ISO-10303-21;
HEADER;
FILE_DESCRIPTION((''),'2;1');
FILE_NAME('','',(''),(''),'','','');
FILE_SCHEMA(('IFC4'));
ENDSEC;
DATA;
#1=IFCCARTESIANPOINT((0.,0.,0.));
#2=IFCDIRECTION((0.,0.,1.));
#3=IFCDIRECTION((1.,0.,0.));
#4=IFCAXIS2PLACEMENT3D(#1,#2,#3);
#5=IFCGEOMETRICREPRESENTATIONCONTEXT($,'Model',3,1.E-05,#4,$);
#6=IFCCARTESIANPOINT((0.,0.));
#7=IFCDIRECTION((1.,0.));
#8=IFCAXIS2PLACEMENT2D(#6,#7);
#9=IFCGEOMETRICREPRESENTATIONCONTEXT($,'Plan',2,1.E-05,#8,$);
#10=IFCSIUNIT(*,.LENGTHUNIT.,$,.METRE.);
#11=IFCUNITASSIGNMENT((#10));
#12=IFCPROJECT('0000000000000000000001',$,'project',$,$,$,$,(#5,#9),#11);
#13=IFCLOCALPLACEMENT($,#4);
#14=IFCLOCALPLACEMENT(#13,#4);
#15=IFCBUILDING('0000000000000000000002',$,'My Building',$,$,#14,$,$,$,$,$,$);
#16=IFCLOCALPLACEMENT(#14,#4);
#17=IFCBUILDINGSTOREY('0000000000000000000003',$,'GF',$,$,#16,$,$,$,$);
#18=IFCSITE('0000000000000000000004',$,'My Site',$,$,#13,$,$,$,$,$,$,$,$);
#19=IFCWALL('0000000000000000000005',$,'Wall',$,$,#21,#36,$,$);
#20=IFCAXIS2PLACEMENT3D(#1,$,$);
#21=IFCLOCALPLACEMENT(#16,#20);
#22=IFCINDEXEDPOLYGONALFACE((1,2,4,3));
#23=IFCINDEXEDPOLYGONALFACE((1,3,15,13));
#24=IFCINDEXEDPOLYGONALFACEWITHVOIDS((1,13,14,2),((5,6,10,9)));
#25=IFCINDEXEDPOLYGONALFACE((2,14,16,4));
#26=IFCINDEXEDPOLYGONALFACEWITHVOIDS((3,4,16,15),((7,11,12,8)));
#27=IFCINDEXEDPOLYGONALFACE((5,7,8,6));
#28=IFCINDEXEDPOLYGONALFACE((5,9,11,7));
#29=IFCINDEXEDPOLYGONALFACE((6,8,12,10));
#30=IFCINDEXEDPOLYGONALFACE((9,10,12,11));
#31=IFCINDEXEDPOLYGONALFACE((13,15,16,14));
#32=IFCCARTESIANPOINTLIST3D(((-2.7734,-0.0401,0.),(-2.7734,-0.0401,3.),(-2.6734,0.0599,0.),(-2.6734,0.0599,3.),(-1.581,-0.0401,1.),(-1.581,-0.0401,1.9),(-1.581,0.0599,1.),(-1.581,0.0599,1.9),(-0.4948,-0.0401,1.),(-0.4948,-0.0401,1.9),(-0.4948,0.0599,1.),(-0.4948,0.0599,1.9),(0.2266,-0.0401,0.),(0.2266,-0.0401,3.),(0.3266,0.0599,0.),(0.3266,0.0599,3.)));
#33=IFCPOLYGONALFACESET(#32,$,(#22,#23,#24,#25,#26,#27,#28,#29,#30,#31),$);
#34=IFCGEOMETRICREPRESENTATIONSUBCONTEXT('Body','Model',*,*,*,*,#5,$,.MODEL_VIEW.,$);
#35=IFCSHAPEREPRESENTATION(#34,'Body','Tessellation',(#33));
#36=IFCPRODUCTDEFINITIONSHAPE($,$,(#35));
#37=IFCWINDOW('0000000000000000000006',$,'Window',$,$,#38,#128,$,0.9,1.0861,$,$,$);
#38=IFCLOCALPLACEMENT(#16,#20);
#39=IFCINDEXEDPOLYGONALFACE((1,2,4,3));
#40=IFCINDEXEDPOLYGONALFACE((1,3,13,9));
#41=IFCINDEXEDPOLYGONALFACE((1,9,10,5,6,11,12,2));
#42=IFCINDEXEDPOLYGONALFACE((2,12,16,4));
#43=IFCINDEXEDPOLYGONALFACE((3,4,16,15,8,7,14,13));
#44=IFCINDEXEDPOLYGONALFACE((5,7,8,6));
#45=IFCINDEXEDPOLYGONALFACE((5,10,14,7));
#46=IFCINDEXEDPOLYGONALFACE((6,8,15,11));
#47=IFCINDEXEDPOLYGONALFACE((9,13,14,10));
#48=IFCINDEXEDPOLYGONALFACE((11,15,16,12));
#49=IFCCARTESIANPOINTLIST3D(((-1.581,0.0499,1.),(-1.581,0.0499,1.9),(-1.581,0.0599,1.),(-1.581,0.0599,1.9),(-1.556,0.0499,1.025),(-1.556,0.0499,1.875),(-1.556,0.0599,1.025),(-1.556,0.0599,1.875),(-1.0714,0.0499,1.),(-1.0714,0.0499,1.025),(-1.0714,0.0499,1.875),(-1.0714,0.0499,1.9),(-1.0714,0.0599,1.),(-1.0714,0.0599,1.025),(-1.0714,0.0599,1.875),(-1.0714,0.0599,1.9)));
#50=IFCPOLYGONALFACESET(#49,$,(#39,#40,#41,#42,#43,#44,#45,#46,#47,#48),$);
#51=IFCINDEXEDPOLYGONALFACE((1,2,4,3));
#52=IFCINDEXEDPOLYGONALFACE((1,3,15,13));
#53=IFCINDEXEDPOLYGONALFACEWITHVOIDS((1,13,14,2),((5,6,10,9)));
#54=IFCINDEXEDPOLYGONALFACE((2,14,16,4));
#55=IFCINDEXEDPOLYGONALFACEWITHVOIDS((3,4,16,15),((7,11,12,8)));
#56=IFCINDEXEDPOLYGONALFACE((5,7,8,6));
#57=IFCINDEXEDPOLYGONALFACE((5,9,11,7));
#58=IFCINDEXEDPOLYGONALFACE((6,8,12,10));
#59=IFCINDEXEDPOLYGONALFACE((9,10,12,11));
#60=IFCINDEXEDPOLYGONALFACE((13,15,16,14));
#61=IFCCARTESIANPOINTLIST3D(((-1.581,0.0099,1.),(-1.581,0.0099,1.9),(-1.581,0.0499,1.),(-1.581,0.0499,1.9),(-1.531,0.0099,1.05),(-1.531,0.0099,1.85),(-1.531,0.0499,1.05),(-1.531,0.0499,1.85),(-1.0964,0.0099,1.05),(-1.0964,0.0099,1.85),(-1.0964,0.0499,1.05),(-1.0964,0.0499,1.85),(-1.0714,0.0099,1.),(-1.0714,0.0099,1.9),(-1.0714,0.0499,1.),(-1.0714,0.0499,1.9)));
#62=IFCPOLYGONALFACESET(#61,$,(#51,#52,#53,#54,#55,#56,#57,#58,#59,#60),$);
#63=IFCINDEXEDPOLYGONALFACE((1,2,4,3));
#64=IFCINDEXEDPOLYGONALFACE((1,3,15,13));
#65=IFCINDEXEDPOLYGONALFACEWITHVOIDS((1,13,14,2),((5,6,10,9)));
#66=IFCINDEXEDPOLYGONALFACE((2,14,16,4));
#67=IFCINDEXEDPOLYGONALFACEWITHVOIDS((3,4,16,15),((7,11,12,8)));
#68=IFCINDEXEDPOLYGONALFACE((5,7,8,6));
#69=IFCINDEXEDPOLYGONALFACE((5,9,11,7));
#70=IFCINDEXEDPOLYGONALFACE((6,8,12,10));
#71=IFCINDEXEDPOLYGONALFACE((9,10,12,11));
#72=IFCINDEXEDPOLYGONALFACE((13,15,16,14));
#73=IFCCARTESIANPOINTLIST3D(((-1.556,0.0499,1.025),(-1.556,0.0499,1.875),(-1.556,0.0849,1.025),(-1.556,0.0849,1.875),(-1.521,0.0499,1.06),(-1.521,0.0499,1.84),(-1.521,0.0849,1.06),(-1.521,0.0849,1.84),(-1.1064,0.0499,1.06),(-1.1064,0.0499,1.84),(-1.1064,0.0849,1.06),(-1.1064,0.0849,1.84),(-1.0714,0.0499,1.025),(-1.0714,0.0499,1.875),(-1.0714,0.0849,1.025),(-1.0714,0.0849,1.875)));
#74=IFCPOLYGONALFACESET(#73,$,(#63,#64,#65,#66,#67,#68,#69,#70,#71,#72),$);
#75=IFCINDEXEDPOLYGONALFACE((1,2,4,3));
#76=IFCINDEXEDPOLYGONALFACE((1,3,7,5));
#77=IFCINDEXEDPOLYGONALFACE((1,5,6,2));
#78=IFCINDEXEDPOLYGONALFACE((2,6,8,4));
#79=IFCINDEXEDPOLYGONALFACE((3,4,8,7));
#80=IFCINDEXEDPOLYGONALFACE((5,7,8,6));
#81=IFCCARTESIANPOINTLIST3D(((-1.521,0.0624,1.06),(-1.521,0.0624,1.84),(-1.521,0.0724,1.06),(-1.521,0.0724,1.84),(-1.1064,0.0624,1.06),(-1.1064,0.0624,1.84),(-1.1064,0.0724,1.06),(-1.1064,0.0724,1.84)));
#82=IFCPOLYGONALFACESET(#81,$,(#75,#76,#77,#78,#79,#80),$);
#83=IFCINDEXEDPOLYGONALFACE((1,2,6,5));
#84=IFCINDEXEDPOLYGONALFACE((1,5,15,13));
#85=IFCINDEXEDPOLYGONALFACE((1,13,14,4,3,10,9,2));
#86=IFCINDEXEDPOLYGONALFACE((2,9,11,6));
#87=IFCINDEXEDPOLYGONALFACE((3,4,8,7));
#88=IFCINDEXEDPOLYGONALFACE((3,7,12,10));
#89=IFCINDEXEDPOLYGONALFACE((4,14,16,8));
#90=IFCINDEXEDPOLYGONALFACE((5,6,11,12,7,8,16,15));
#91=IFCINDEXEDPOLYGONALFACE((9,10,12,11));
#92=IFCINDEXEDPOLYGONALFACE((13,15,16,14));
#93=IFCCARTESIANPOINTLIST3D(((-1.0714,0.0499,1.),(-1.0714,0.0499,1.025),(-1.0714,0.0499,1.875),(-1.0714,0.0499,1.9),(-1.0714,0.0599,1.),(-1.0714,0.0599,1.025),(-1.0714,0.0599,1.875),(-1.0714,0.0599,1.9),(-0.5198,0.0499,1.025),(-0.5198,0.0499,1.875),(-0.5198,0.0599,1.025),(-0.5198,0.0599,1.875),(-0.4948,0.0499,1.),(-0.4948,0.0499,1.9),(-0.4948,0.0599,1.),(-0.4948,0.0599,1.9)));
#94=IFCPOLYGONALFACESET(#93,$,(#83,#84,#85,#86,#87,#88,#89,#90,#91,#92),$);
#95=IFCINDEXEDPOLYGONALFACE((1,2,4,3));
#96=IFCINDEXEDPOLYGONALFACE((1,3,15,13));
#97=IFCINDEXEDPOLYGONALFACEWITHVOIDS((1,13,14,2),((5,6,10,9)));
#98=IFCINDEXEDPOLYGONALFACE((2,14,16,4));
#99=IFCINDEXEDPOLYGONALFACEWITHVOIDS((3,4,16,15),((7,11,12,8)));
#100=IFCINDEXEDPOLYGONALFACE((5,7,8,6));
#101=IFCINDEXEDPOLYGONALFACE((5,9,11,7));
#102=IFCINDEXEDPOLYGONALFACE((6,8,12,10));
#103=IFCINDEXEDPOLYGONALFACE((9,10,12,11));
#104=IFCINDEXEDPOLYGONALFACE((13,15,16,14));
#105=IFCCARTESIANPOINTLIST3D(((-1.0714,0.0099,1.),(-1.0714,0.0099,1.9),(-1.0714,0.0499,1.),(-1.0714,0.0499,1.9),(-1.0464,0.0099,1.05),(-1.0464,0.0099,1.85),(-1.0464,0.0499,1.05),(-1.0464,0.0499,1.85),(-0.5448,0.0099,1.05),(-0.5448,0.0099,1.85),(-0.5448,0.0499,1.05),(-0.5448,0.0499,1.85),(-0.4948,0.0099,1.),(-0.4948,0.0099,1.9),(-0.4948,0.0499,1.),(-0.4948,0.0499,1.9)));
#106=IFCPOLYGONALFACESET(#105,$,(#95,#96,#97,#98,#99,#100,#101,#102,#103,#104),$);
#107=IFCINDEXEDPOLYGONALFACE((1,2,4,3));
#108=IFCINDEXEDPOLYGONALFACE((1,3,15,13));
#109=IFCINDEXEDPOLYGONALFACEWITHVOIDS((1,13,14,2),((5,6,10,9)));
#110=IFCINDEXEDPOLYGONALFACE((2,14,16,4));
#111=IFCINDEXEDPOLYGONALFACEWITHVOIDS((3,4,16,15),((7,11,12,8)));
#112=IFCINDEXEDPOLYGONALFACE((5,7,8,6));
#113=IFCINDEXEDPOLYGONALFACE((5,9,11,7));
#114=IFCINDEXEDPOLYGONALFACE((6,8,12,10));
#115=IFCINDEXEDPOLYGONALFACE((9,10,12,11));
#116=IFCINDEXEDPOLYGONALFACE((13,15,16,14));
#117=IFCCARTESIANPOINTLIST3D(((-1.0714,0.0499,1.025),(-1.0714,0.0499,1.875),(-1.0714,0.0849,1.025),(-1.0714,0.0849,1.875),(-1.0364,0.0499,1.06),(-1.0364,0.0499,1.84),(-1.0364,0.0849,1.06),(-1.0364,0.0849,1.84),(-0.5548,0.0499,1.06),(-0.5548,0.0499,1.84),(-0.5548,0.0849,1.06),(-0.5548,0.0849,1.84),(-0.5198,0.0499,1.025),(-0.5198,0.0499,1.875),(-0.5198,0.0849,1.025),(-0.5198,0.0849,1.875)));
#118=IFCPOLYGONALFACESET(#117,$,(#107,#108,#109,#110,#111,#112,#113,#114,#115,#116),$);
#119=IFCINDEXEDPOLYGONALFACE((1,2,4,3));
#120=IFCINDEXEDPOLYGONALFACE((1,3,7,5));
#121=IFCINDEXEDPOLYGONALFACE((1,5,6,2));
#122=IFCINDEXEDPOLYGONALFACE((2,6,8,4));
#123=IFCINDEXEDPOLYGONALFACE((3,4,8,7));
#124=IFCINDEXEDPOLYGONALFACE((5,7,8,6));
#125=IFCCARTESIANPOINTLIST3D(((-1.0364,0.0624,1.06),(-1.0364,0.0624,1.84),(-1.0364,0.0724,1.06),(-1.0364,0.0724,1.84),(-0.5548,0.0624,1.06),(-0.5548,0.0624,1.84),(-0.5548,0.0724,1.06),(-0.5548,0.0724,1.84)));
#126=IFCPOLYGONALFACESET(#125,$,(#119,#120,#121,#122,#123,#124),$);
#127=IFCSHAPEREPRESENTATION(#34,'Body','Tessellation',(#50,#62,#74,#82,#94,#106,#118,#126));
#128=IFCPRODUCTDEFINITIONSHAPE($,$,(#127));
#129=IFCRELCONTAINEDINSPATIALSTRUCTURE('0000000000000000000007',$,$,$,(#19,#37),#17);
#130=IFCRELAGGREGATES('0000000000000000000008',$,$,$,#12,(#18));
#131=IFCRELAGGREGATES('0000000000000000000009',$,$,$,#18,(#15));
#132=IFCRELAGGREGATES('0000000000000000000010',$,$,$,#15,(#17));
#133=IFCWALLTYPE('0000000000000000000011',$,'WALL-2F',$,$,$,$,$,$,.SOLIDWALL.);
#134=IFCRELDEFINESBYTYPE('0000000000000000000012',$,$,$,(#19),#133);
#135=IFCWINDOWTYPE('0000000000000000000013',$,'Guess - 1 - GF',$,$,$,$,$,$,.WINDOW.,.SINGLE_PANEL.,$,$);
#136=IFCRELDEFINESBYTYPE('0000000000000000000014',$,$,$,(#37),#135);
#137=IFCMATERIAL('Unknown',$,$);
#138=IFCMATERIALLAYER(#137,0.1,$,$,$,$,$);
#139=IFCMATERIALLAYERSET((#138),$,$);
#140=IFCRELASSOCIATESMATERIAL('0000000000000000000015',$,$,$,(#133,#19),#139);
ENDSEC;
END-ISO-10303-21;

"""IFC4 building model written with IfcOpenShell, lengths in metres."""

from ifc_helpers import new_model, entity, si_unit, frame, origin_with_axes, origin_2d_with_axis, place, context, subcontext, project, spatial, line, indexed_curve, outline, extrude, shape, source, transform, mapped, material, layer, layer_set, layer_usage, type_object, type_shapes, element, fill, save


model = new_model("IFC4")

# Units and contexts
model_context = context("Model", 3, precision=1e-05, world=origin_with_axes())
plan_context = context("Plan", 2, precision=1e-05, world=origin_2d_with_axis())
body_context_1 = subcontext(model_context, "Body", "Model", "MODEL_VIEW")
body_context_2 = subcontext(plan_context, "Body", "Plan", "PLAN_VIEW")
ifc_project = project(units=[si_unit("LENGTHUNIT", "METRE")], contexts=[model_context, plan_context])

# Site, building, storey
site_placement = place(None, origin_with_axes())
site = spatial("IfcSite", under=ifc_project, at=site_placement, Name="My Site")
building_placement = place(site_placement, origin_with_axes())
building = spatial("IfcBuilding", under=site, at=building_placement, Name="My Building")
storey_placement = place(building_placement, origin_with_axes())
storey = spatial("IfcBuildingStorey", under=building, at=storey_placement, Name="GF")

# Shared definitions
ifc_material = material(Name="Unknown")

# Shared definitions
ifc_layer_1 = layer(ifc_material, 0.1)
ifc_layer_set_1 = layer_set([ifc_layer_1])
wall_type_1 = type_object("IfcWallType", Name="WALL-2F", PredefinedType="SOLIDWALL", material=ifc_layer_set_1)

# Wall, opening, window
ifc_layer_usage_1 = layer_usage(ifc_layer_set_1, "AXIS2", "POSITIVE", 0.0)
wall_1_placement = place(storey_placement, frame((-2.7734, -0.0401, 0.0), z_axis=(0.0, 0.0, 1.0), x_axis=(1.0, 0.0, 0.0)))
wall_1 = element("IfcWall", 1, at=wall_1_placement, inside=storey, type_object=wall_type_1, material=ifc_layer_usage_1, Name="Wall", context=body_context_1, shape_type="SweptSolid", body=[
    extrude(outline(indexed_curve([(0.0, 0.0), (0.1, 0.1), (3.1, 0.1), (3.0, 0.0)], segments=[line(1, 2, 3, 4, 1)])), origin_with_axes(), (0.0, 0.0, 1.0), 3.0),
])
shared_shape_1 = source(origin_with_axes(), body_context_1, "Body", "SweptSolid", [
    extrude(outline(indexed_curve([(0.0, 0.0), (1.0861, 0.0), (1.0861, 0.9), (0.0, 0.9)], segments=[line(1, 2, 3, 4, 1)])), frame((0.0, -0.6, 0.0), z_axis=(0.0, -1.0, 0.0), x_axis=(1.0, 0.0, 0.0)), (0.0, 0.0, -1.0), 1.2),
])
opening_1_placement = place(wall_1_placement, frame((1.1924, 0.0, 1.0), z_axis=(0.0, 0.0, 1.0), x_axis=(1.0, 0.0, 0.0)))
opening_1 = element("IfcOpeningElement", 2, at=opening_1_placement, cuts=wall_1, PredefinedType="OPENING", context=body_context_1, shape_type="MappedRepresentation", body=[
    mapped(shared_shape_1, transform((0.0, 0.0, 0.0), x_axis=(1.0, 0.0, 0.0), y_axis=(0.0, 1.0, 0.0), z_axis=(0.0, 0.0, 1.0), scale=1.0)),
])
window_type_1 = type_object("IfcWindowType", Name="Guess - 1 - GF", PartitioningType="SINGLE_PANEL", PredefinedType="WINDOW")
shared_shape_2 = source(origin_with_axes(), body_context_1, "Body", "SweptSolid", [
    extrude(outline(indexed_curve([(0.5096, 0.0), (0.0, 0.0), (0.0, 0.9), (0.5096, 0.9), (0.5096, 0.875), (0.025, 0.875), (0.025, 0.025), (0.5096, 0.025)], segments=[line(1, 2, 3, 4, 5, 6, 7, 8, 1)])), frame((0.0, 0.09, 0.0), z_axis=(0.0, -1.0, 0.0), x_axis=(1.0, 0.0, 0.0)), (0.0, 0.0, -1.0), 0.01),
    extrude(outline(indexed_curve([(0.0, 0.0), (0.5096, 0.0), (0.5096, 0.9), (0.0, 0.9)], segments=[line(1, 2, 3, 4, 1)]), holes=[indexed_curve([(0.05, 0.05), (0.4846, 0.05), (0.4846, 0.85), (0.05, 0.85)], segments=[line(1, 2, 3, 4, 1)])]), frame((0.0, 0.05, 0.0), z_axis=(0.0, -1.0, 0.0), x_axis=(1.0, 0.0, 0.0)), (0.0, 0.0, -1.0), 0.04),
    extrude(outline(indexed_curve([(0.0, 0.0), (0.4846, 0.0), (0.4846, 0.85), (0.0, 0.85)], segments=[line(1, 2, 3, 4, 1)]), holes=[indexed_curve([(0.035, 0.035), (0.4496, 0.035), (0.4496, 0.815), (0.035, 0.815)], segments=[line(1, 2, 3, 4, 1)])]), frame((0.025, 0.09, 0.025), z_axis=(0.0, -1.0, 0.0), x_axis=(1.0, 0.0, 0.0)), (0.0, 0.0, -1.0), 0.035),
    extrude(outline(indexed_curve([(0.035, 0.035), (0.4496, 0.035), (0.4496, 0.815), (0.035, 0.815)], segments=[line(1, 2, 3, 4, 1)])), frame((0.025, 0.1025, 0.025), z_axis=(0.0, -1.0, 0.0), x_axis=(1.0, 0.0, 0.0)), (0.0, 0.0, -1.0), 0.01),
    extrude(outline(indexed_curve([(0.0, 0.9), (0.5766, 0.9), (0.5766, 0.0), (0.0, 0.0), (0.0, 0.025), (0.5516, 0.025), (0.5516, 0.875), (0.0, 0.875)], segments=[line(1, 2, 3, 4, 5, 6, 7, 8, 1)])), frame((0.5096, 0.09, 0.0), z_axis=(0.0, -1.0, 0.0), x_axis=(1.0, 0.0, 0.0)), (0.0, 0.0, -1.0), 0.01),
    extrude(outline(indexed_curve([(0.0, 0.0), (0.5766, 0.0), (0.5766, 0.9), (0.0, 0.9)], segments=[line(1, 2, 3, 4, 1)]), holes=[indexed_curve([(0.025, 0.05), (0.5266, 0.05), (0.5266, 0.85), (0.025, 0.85)], segments=[line(1, 2, 3, 4, 1)])]), frame((0.5096, 0.05, 0.0), z_axis=(0.0, -1.0, 0.0), x_axis=(1.0, 0.0, 0.0)), (0.0, 0.0, -1.0), 0.04),
    extrude(outline(indexed_curve([(0.0, 0.0), (0.5516, 0.0), (0.5516, 0.85), (0.0, 0.85)], segments=[line(1, 2, 3, 4, 1)]), holes=[indexed_curve([(0.035, 0.035), (0.5166, 0.035), (0.5166, 0.815), (0.035, 0.815)], segments=[line(1, 2, 3, 4, 1)])]), frame((0.5096, 0.09, 0.025), z_axis=(0.0, -1.0, 0.0), x_axis=(1.0, 0.0, 0.0)), (0.0, 0.0, -1.0), 0.035),
    extrude(outline(indexed_curve([(0.035, 0.035), (0.5166, 0.035), (0.5166, 0.815), (0.035, 0.815)], segments=[line(1, 2, 3, 4, 1)])), frame((0.5096, 0.1025, 0.025), z_axis=(0.0, -1.0, 0.0), x_axis=(1.0, 0.0, 0.0)), (0.0, 0.0, -1.0), 0.01),
])
shared_shape_3 = source(origin_with_axes(), body_context_2, "Body", "Curve2D", [
    entity("IfcIndexedPolyCurve", entity("IfcCartesianPointList2D", [[0.05, 0.05], [0.4846, 0.05]])),
    entity("IfcIndexedPolyCurve", entity("IfcCartesianPointList2D", [[0.0, 0.1], [0.025, 0.1], [0.025, 0.09], [0.05, 0.09], [0.05, 0.05], [0.0, 0.05]]), [entity("IfcLineIndex", [1, 2, 3, 4, 5, 6, 1])]),
    entity("IfcIndexedPolyCurve", entity("IfcCartesianPointList2D", [[0.5096, 0.1], [0.5096, 0.1], [0.5096, 0.09], [0.4846, 0.09], [0.4846, 0.05], [0.5096, 0.05]])),
    entity("IfcIndexedPolyCurve", entity("IfcCartesianPointList2D", [[0.025, 0.09], [0.06, 0.09], [0.06, 0.125], [0.025, 0.125]]), [entity("IfcLineIndex", [1, 2, 3, 4, 1])]),
    entity("IfcIndexedPolyCurve", entity("IfcCartesianPointList2D", [[0.5096, 0.09], [0.4746, 0.09], [0.4746, 0.125], [0.5096, 0.125]]), [entity("IfcLineIndex", [1, 2, 3, 4, 1])]),
    entity("IfcIndexedPolyCurve", entity("IfcCartesianPointList2D", [[0.06, 0.09], [0.4746, 0.09]])),
    entity("IfcIndexedPolyCurve", entity("IfcCartesianPointList2D", [[0.06, 0.125], [0.4746, 0.125]])),
    entity("IfcIndexedPolyCurve", entity("IfcCartesianPointList2D", [[0.06, 0.1075], [0.4746, 0.1075]])),
    entity("IfcIndexedPolyCurve", entity("IfcCartesianPointList2D", [[0.5346, 0.05], [1.0361, 0.05]])),
    entity("IfcIndexedPolyCurve", entity("IfcCartesianPointList2D", [[0.5096, 0.1], [0.5096, 0.1], [0.5096, 0.09], [0.5346, 0.09], [0.5346, 0.05], [0.5096, 0.05]])),
    entity("IfcIndexedPolyCurve", entity("IfcCartesianPointList2D", [[1.0861, 0.1], [1.0611, 0.1], [1.0611, 0.09], [1.0361, 0.09], [1.0361, 0.05], [1.0861, 0.05]]), [entity("IfcLineIndex", [1, 2, 3, 4, 5, 6, 1])]),
    entity("IfcIndexedPolyCurve", entity("IfcCartesianPointList2D", [[0.5096, 0.09], [0.5446, 0.09], [0.5446, 0.125], [0.5096, 0.125]]), [entity("IfcLineIndex", [1, 2, 3, 4, 1])]),
    entity("IfcIndexedPolyCurve", entity("IfcCartesianPointList2D", [[1.0611, 0.09], [1.0261, 0.09], [1.0261, 0.125], [1.0611, 0.125]]), [entity("IfcLineIndex", [1, 2, 3, 4, 1])]),
    entity("IfcIndexedPolyCurve", entity("IfcCartesianPointList2D", [[0.5446, 0.09], [1.0261, 0.09]])),
    entity("IfcIndexedPolyCurve", entity("IfcCartesianPointList2D", [[0.5446, 0.125], [1.0261, 0.125]])),
    entity("IfcIndexedPolyCurve", entity("IfcCartesianPointList2D", [[0.5446, 0.1075], [1.0261, 0.1075]])),
])
type_shapes(window_type_1, [shared_shape_2, shared_shape_3])
window_1_placement = place(opening_1_placement, frame((0.0, 0.0, 0.0), z_axis=(0.0, 0.0, 1.0), x_axis=(1.0, 0.0, 0.0)))
window_1 = element("IfcWindow", 3, at=window_1_placement, inside=storey, type_object=window_type_1, Name="Window", OverallHeight=0.9, OverallWidth=1.0861, shapes=[
    shape(body_context_1, "Body", "MappedRepresentation", [mapped(shared_shape_2, transform((0.0, 0.0, 0.0), x_axis=(1.0, 0.0, 0.0), y_axis=(0.0, 1.0, 0.0), z_axis=(0.0, 0.0, 1.0), scale=1.0))]),
    shape(body_context_2, "Body", "MappedRepresentation", [mapped(shared_shape_3, transform((0.0, 0.0, 0.0), x_axis=(1.0, 0.0, 0.0), y_axis=(0.0, 1.0, 0.0), z_axis=(0.0, 0.0, 1.0), scale=1.0))]),
])
fill(opening_1, window_1)

save(model, "model.ifc")
